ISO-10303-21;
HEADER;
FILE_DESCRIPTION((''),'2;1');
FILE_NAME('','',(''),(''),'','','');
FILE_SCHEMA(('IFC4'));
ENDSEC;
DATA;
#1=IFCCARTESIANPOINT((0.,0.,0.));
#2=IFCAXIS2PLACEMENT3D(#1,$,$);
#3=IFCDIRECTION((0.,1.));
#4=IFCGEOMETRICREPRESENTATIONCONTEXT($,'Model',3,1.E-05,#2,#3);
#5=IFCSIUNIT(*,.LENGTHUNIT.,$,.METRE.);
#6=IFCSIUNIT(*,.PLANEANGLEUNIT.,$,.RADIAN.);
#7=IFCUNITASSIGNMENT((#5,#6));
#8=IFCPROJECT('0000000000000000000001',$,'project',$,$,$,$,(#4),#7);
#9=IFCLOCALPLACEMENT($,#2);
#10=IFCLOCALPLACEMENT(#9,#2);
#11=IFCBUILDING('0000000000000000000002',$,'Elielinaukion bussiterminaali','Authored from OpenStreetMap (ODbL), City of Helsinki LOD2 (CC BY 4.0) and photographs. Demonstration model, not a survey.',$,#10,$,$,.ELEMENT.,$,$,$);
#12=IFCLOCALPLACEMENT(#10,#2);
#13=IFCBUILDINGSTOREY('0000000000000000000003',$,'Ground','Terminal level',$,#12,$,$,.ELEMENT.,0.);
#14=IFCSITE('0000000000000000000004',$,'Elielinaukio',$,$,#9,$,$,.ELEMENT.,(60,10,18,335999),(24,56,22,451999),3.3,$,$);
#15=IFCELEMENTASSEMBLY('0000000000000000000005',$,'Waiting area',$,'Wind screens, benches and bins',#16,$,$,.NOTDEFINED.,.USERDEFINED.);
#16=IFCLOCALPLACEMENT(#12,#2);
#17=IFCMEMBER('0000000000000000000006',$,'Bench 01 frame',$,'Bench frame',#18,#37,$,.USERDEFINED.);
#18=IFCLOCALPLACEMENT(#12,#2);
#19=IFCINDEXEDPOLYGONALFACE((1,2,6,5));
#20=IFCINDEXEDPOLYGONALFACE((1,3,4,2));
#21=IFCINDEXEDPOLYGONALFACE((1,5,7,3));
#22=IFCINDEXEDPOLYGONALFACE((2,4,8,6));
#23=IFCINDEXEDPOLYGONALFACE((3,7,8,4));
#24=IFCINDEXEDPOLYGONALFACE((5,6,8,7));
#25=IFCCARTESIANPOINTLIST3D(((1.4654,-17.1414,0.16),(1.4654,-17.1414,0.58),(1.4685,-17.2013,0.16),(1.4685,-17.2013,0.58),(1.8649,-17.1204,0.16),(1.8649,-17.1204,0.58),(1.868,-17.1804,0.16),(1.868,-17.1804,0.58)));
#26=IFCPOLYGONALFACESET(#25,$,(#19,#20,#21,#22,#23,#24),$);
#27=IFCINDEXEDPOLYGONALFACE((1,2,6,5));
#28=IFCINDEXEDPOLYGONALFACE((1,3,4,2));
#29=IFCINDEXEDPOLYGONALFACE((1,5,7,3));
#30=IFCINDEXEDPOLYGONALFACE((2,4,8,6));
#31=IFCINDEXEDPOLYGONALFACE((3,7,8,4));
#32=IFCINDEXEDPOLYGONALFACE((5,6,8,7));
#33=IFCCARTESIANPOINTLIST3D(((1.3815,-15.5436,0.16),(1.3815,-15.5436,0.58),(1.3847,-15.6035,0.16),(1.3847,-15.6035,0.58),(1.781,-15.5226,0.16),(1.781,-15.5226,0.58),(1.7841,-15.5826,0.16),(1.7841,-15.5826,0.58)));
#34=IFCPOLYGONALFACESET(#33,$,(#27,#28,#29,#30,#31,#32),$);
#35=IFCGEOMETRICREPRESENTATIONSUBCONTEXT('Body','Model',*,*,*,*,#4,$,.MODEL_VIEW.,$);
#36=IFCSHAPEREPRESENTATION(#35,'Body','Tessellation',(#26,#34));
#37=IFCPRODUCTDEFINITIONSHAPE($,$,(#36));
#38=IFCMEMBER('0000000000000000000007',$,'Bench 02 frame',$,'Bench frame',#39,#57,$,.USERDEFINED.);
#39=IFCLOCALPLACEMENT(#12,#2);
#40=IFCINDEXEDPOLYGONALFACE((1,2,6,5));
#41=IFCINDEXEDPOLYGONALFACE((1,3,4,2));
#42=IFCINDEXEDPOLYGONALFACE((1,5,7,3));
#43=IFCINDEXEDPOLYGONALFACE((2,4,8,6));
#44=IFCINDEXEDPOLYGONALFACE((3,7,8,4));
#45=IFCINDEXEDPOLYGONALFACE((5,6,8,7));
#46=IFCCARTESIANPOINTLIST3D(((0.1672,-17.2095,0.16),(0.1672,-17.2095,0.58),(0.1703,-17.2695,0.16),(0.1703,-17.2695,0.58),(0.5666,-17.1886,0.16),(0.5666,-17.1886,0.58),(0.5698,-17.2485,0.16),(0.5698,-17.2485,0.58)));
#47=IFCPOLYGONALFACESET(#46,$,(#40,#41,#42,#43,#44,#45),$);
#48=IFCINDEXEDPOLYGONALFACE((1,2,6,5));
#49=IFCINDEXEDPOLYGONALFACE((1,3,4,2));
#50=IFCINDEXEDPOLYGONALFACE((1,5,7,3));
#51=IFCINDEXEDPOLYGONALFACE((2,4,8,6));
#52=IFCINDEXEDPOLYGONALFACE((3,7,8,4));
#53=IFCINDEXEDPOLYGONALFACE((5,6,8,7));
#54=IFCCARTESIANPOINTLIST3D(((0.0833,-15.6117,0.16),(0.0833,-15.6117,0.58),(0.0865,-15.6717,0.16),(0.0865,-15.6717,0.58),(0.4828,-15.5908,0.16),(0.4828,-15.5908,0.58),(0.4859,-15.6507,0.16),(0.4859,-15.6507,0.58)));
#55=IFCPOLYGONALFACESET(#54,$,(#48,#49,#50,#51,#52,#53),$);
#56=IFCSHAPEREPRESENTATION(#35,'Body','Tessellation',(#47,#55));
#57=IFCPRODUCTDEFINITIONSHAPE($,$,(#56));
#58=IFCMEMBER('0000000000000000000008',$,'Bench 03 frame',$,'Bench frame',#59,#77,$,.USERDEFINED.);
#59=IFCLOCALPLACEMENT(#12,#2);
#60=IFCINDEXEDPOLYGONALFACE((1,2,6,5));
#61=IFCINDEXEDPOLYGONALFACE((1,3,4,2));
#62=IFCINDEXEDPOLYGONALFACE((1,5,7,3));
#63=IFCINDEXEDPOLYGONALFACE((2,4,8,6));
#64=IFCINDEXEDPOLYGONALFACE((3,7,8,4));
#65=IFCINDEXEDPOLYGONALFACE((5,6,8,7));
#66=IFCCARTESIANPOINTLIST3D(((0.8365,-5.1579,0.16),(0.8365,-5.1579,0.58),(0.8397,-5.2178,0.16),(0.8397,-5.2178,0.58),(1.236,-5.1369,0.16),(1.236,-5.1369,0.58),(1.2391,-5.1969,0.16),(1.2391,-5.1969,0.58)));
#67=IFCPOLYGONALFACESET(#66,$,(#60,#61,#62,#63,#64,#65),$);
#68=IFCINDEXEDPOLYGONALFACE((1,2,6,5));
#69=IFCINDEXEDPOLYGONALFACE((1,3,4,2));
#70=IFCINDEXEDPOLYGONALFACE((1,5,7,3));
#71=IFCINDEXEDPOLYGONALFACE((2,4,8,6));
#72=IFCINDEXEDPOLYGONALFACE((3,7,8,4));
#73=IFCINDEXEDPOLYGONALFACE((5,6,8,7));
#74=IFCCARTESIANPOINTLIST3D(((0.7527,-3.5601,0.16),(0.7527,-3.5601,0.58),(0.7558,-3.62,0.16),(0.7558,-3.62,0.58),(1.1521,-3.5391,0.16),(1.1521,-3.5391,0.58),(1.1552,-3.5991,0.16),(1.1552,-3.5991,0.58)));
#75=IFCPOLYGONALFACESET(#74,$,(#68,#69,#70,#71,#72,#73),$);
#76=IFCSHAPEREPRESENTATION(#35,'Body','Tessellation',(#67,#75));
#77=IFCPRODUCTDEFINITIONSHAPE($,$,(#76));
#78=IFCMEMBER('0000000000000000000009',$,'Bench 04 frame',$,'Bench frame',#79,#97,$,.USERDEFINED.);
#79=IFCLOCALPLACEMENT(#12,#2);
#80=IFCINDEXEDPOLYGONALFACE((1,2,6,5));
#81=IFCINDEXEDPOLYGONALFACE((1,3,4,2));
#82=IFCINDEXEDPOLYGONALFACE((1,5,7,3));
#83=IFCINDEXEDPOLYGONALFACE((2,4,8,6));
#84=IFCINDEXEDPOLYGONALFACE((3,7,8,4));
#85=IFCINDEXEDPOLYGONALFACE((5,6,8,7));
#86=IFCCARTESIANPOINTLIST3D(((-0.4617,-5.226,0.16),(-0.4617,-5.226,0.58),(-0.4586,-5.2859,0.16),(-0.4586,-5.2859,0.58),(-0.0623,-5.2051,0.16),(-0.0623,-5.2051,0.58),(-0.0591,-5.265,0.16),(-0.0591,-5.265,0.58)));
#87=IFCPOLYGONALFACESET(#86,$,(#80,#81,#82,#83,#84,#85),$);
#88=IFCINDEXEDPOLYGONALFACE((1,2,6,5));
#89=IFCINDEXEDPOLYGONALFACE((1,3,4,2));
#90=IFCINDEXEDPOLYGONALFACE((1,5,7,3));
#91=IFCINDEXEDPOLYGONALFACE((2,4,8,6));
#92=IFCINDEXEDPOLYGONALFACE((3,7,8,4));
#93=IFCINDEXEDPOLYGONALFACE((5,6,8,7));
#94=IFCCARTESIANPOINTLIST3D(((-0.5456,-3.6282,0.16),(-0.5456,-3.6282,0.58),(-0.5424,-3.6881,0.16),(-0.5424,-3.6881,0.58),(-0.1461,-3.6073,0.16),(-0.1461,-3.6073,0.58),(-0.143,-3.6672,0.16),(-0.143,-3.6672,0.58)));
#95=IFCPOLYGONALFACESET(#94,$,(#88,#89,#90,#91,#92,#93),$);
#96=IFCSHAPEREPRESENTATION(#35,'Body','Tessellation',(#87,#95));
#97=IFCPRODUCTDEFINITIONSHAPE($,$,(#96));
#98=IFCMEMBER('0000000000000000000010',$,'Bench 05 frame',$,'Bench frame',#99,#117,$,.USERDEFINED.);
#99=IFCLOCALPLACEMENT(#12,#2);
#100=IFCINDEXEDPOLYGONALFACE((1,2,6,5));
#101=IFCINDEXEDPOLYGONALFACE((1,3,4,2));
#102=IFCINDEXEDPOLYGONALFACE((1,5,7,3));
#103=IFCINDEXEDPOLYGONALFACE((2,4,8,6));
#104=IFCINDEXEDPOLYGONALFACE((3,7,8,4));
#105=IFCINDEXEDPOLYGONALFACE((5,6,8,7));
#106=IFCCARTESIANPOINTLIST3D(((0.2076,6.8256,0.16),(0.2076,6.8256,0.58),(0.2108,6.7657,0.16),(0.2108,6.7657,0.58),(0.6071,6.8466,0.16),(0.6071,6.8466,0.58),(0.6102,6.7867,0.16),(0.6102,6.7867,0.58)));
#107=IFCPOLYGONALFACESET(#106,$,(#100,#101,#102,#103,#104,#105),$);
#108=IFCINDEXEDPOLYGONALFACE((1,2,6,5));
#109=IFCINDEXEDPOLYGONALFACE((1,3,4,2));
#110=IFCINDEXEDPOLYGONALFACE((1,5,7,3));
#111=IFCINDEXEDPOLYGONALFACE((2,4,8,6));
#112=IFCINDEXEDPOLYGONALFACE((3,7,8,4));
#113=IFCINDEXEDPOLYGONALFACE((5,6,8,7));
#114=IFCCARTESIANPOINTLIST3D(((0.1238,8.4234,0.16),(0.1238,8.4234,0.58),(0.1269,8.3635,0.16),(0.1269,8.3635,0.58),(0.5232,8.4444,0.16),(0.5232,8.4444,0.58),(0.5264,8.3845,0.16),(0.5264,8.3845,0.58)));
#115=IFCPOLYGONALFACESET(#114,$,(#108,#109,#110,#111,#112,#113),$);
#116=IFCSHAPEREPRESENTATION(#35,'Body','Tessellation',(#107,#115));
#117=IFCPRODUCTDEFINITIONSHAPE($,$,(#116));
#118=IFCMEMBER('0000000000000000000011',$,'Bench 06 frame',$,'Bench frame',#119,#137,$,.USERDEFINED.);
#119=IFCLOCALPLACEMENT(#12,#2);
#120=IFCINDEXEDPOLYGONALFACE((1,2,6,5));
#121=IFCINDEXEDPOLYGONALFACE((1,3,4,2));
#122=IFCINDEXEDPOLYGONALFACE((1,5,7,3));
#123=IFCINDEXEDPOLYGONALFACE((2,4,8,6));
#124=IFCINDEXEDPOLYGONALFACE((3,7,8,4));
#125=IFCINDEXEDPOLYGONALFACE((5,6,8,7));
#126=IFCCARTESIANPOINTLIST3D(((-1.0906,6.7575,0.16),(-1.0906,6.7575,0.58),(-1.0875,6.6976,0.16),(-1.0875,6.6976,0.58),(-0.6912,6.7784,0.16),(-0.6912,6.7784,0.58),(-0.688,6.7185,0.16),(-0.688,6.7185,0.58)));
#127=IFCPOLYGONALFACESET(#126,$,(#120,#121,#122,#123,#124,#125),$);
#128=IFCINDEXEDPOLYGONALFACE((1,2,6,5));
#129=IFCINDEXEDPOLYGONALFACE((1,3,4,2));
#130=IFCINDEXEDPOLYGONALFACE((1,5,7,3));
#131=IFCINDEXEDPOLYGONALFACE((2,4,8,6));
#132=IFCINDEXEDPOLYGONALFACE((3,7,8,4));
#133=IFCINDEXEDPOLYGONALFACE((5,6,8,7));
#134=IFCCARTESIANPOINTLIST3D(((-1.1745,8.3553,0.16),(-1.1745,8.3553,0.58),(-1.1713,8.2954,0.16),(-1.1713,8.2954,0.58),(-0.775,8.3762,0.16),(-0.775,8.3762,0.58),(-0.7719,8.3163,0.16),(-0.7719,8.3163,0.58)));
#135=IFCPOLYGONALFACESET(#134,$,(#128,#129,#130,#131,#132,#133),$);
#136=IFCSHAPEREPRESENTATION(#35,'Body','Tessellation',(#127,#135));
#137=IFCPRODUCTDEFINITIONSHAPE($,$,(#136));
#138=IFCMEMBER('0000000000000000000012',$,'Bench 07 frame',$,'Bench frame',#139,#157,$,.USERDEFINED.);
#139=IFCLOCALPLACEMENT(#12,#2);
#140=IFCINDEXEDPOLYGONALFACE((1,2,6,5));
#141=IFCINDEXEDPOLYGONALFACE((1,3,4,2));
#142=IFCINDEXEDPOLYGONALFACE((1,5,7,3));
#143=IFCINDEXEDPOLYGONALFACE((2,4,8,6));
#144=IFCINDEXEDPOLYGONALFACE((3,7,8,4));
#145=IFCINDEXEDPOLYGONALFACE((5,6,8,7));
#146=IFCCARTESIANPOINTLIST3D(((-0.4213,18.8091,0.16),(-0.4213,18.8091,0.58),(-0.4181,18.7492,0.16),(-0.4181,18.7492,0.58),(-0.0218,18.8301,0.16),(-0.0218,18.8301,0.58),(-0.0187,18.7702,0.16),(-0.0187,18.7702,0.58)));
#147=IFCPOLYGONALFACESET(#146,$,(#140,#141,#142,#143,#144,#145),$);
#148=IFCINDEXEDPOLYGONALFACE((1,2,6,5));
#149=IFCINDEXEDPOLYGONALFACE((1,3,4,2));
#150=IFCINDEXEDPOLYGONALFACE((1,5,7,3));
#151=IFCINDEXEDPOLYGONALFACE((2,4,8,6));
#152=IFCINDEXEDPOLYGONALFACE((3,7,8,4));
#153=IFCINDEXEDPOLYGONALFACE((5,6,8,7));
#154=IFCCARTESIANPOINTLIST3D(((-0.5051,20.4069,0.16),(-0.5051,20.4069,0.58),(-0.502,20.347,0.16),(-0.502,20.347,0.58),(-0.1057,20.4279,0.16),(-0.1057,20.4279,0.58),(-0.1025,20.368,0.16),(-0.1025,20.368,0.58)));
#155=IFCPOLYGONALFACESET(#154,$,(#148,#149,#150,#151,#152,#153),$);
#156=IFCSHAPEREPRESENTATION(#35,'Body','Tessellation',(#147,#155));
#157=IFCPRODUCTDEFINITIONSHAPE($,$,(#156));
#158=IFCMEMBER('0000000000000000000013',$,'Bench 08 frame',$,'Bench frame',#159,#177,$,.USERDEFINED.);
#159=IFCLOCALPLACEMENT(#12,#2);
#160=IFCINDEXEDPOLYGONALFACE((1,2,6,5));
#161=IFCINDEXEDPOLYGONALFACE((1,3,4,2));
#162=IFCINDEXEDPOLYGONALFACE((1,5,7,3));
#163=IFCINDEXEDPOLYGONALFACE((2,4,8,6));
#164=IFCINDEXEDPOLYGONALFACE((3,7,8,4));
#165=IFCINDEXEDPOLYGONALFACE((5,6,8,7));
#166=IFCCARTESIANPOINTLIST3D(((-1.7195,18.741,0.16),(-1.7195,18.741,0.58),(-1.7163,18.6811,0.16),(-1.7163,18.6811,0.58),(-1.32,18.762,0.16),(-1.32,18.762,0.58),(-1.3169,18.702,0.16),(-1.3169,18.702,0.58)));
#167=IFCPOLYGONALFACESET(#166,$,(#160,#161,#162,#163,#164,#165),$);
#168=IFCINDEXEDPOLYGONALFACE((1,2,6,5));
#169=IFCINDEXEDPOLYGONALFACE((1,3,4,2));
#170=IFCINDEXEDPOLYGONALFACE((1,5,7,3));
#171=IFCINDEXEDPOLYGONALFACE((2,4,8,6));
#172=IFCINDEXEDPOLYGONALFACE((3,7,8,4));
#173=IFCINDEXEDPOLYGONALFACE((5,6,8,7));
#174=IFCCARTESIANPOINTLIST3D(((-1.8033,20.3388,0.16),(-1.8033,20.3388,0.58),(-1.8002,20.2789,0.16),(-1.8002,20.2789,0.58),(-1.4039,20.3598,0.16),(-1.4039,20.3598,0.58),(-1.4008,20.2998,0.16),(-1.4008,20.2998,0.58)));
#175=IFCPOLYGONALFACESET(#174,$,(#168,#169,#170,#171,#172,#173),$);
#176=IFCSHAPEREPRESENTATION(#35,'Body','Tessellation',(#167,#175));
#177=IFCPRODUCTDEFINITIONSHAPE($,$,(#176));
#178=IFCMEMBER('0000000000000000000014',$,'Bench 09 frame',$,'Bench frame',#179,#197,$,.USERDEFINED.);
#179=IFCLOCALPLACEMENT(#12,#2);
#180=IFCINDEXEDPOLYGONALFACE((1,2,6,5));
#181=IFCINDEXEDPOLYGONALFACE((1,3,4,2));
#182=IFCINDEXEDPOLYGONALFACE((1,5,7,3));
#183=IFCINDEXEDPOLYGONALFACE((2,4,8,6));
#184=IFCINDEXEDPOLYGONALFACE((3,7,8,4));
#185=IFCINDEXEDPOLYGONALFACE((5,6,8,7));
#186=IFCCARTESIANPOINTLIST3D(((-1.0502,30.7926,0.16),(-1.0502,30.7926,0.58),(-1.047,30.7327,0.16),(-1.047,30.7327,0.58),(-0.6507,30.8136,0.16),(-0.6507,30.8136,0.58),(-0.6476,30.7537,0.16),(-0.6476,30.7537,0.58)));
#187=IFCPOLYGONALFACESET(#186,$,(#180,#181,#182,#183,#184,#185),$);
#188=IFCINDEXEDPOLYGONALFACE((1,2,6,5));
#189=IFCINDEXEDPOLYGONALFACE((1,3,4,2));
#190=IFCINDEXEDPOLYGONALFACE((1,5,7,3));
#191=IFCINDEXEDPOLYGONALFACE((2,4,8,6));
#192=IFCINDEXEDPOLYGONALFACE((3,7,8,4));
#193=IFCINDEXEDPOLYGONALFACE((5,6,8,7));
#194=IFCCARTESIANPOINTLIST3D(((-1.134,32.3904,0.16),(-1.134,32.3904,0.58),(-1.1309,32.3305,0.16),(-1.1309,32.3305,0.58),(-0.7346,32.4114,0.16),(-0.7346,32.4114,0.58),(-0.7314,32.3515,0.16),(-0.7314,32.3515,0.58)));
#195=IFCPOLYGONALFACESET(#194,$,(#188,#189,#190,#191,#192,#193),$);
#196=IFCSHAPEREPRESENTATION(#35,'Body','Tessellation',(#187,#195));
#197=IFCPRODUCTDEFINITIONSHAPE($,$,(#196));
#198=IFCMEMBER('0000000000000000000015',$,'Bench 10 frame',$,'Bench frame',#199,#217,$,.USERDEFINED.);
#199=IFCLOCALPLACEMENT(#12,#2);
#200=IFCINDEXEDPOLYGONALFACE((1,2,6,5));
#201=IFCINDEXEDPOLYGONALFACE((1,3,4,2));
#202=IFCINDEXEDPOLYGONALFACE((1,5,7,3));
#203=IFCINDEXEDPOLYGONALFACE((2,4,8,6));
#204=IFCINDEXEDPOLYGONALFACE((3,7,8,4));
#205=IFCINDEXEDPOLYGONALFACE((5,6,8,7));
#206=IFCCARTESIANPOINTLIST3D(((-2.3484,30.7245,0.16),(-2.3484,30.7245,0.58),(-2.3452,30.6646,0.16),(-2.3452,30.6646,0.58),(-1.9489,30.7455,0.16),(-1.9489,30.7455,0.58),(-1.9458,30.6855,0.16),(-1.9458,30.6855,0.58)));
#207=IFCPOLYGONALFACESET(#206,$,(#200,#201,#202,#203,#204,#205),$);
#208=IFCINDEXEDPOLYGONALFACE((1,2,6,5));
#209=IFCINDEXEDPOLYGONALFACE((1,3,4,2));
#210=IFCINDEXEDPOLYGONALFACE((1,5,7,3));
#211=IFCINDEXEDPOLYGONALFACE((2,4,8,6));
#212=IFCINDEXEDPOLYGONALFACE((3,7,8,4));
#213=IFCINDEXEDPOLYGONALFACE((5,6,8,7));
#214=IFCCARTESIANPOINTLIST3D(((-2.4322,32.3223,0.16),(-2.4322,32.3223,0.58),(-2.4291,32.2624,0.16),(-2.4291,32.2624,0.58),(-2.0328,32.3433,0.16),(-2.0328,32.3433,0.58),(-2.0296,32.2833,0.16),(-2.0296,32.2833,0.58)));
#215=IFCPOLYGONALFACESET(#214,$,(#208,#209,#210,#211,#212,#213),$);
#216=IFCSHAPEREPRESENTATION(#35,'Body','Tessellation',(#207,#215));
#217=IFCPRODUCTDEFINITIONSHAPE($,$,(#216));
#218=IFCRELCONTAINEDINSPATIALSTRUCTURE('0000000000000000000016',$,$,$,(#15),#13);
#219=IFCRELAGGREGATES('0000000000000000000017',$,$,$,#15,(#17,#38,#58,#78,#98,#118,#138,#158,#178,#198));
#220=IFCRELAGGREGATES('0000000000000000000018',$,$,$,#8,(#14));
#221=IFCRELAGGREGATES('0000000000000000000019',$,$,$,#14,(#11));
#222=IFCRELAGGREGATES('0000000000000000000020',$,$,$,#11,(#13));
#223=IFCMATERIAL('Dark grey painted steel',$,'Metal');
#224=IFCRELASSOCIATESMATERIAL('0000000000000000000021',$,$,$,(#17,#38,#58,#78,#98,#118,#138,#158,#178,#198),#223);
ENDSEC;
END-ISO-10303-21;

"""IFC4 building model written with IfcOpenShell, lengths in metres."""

from ifc_helpers import new_model, si_unit, direction, frame, frame_2d, origin, place, context, subcontext, project, spatial, rectangle, extrude, material, element, aggregate, save


model = new_model("IFC4")

# Units and contexts
model_context = context("Model", 3, precision=1e-05, world=origin(), true_north=direction((0.0, 1.0)))
body_context = subcontext(model_context, "Body", "Model", "MODEL_VIEW")
ifc_project = project(units=[si_unit("LENGTHUNIT", "METRE"), si_unit("PLANEANGLEUNIT", "RADIAN")], contexts=[model_context])

# Site, building, storey
site_placement = place(None, origin())
site = spatial("IfcSite", under=ifc_project, at=site_placement, Name="Elielinaukio", CompositionType="ELEMENT", RefLatitude=(60, 10, 18, 335999), RefLongitude=(24, 56, 22, 451999), RefElevation=3.3)
building_placement = place(site_placement, origin())
building = spatial("IfcBuilding", under=site, at=building_placement, Name="Elielinaukion bussiterminaali", Description="Authored from OpenStreetMap (ODbL), City of Helsinki LOD2 (CC BY 4.0) and photographs. Demonstration model, not a survey.", CompositionType="ELEMENT")
storey_placement = place(building_placement, origin())
storey = spatial("IfcBuildingStorey", under=building, at=storey_placement, Name="Ground", Description="Terminal level", CompositionType="ELEMENT", Elevation=0.0)

# Element assembly, members
assembly_1_placement = place(building_placement, origin())
assembly_1 = element("IfcElementAssembly", 1, at=assembly_1_placement, inside=storey, Name="Waiting area", ObjectType="Wind screens, benches and bins", AssemblyPlace="NOTDEFINED", PredefinedType="USERDEFINED")
ifc_material_1 = material(Name="Dark grey painted steel", Category="Metal")
member_1_placement = place(building_placement, origin())
member_1 = element("IfcMember", 2, at=member_1_placement, material=ifc_material_1, Name="Bench 01 frame", ObjectType="Bench frame", PredefinedType="USERDEFINED", context=body_context, shape_type="SweptSolid", body=[
    extrude(rectangle(XDim=0.06, YDim=0.4, at=frame_2d((0.0, 0.0), x_axis=(-0.052408, 0.998626))), frame((1.6667, -17.1609, 0.16)), (0.0, 0.0, 1.0), 0.42),
    extrude(rectangle(XDim=0.06, YDim=0.4, at=frame_2d((0.0, 0.0), x_axis=(-0.052408, 0.998626))), frame((1.5828, -15.5631, 0.16)), (0.0, 0.0, 1.0), 0.42),
])
member_2_placement = place(building_placement, origin())
member_2 = element("IfcMember", 3, at=member_2_placement, material=ifc_material_1, Name="Bench 02 frame", ObjectType="Bench frame", PredefinedType="USERDEFINED", context=body_context, shape_type="SweptSolid", body=[
    extrude(rectangle(XDim=0.06, YDim=0.4, at=frame_2d((0.0, 0.0), x_axis=(-0.052408, 0.998626))), frame((0.3685, -17.229, 0.16)), (0.0, 0.0, 1.0), 0.42),
    extrude(rectangle(XDim=0.06, YDim=0.4, at=frame_2d((0.0, 0.0), x_axis=(-0.052408, 0.998626))), frame((0.2846, -15.6312, 0.16)), (0.0, 0.0, 1.0), 0.42),
])
member_3_placement = place(building_placement, origin())
member_3 = element("IfcMember", 4, at=member_3_placement, material=ifc_material_1, Name="Bench 03 frame", ObjectType="Bench frame", PredefinedType="USERDEFINED", context=body_context, shape_type="SweptSolid", body=[
    extrude(rectangle(XDim=0.06, YDim=0.4, at=frame_2d((0.0, 0.0), x_axis=(-0.052408, 0.998626))), frame((1.0378, -5.1774, 0.16)), (0.0, 0.0, 1.0), 0.42),
    extrude(rectangle(XDim=0.06, YDim=0.4, at=frame_2d((0.0, 0.0), x_axis=(-0.052408, 0.998626))), frame((0.954, -3.5796, 0.16)), (0.0, 0.0, 1.0), 0.42),
])
member_4_placement = place(building_placement, origin())
member_4 = element("IfcMember", 5, at=member_4_placement, material=ifc_material_1, Name="Bench 04 frame", ObjectType="Bench frame", PredefinedType="USERDEFINED", context=body_context, shape_type="SweptSolid", body=[
    extrude(rectangle(XDim=0.06, YDim=0.4, at=frame_2d((0.0, 0.0), x_axis=(-0.052408, 0.998626))), frame((-0.2604, -5.2455, 0.16)), (0.0, 0.0, 1.0), 0.42),
    extrude(rectangle(XDim=0.06, YDim=0.4, at=frame_2d((0.0, 0.0), x_axis=(-0.052408, 0.998626))), frame((-0.3443, -3.6477, 0.16)), (0.0, 0.0, 1.0), 0.42),
])
member_5_placement = place(building_placement, origin())
member_5 = element("IfcMember", 6, at=member_5_placement, material=ifc_material_1, Name="Bench 05 frame", ObjectType="Bench frame", PredefinedType="USERDEFINED", context=body_context, shape_type="SweptSolid", body=[
    extrude(rectangle(XDim=0.06, YDim=0.4, at=frame_2d((0.0, 0.0), x_axis=(-0.052408, 0.998626))), frame((0.4089, 6.8061, 0.16)), (0.0, 0.0, 1.0), 0.42),
    extrude(rectangle(XDim=0.06, YDim=0.4, at=frame_2d((0.0, 0.0), x_axis=(-0.052408, 0.998626))), frame((0.3251, 8.4039, 0.16)), (0.0, 0.0, 1.0), 0.42),
])
member_6_placement = place(building_placement, origin())
member_6 = element("IfcMember", 7, at=member_6_placement, material=ifc_material_1, Name="Bench 06 frame", ObjectType="Bench frame", PredefinedType="USERDEFINED", context=body_context, shape_type="SweptSolid", body=[
    extrude(rectangle(XDim=0.06, YDim=0.4, at=frame_2d((0.0, 0.0), x_axis=(-0.052408, 0.998626))), frame((-0.8893, 6.738, 0.16)), (0.0, 0.0, 1.0), 0.42),
    extrude(rectangle(XDim=0.06, YDim=0.4, at=frame_2d((0.0, 0.0), x_axis=(-0.052408, 0.998626))), frame((-0.9732, 8.3358, 0.16)), (0.0, 0.0, 1.0), 0.42),
])
member_7_placement = place(building_placement, origin())
member_7 = element("IfcMember", 8, at=member_7_placement, material=ifc_material_1, Name="Bench 07 frame", ObjectType="Bench frame", PredefinedType="USERDEFINED", context=body_context, shape_type="SweptSolid", body=[
    extrude(rectangle(XDim=0.06, YDim=0.4, at=frame_2d((0.0, 0.0), x_axis=(-0.052408, 0.998626))), frame((-0.22, 18.7896, 0.16)), (0.0, 0.0, 1.0), 0.42),
    extrude(rectangle(XDim=0.06, YDim=0.4, at=frame_2d((0.0, 0.0), x_axis=(-0.052408, 0.998626))), frame((-0.3038, 20.3874, 0.16)), (0.0, 0.0, 1.0), 0.42),
])
member_8_placement = place(building_placement, origin())
member_8 = element("IfcMember", 9, at=member_8_placement, material=ifc_material_1, Name="Bench 08 frame", ObjectType="Bench frame", PredefinedType="USERDEFINED", context=body_context, shape_type="SweptSolid", body=[
    extrude(rectangle(XDim=0.06, YDim=0.4, at=frame_2d((0.0, 0.0), x_axis=(-0.052408, 0.998626))), frame((-1.5182, 18.7215, 0.16)), (0.0, 0.0, 1.0), 0.42),
    extrude(rectangle(XDim=0.06, YDim=0.4, at=frame_2d((0.0, 0.0), x_axis=(-0.052408, 0.998626))), frame((-1.602, 20.3193, 0.16)), (0.0, 0.0, 1.0), 0.42),
])
member_9_placement = place(building_placement, origin())
member_9 = element("IfcMember", 10, at=member_9_placement, material=ifc_material_1, Name="Bench 09 frame", ObjectType="Bench frame", PredefinedType="USERDEFINED", context=body_context, shape_type="SweptSolid", body=[
    extrude(rectangle(XDim=0.06, YDim=0.4, at=frame_2d((0.0, 0.0), x_axis=(-0.052408, 0.998626))), frame((-0.8489, 30.7732, 0.16)), (0.0, 0.0, 1.0), 0.42),
    extrude(rectangle(XDim=0.06, YDim=0.4, at=frame_2d((0.0, 0.0), x_axis=(-0.052408, 0.998626))), frame((-0.9327, 32.371, 0.16)), (0.0, 0.0, 1.0), 0.42),
])
member_10_placement = place(building_placement, origin())
member_10 = element("IfcMember", 11, at=member_10_placement, material=ifc_material_1, Name="Bench 10 frame", ObjectType="Bench frame", PredefinedType="USERDEFINED", context=body_context, shape_type="SweptSolid", body=[
    extrude(rectangle(XDim=0.06, YDim=0.4, at=frame_2d((0.0, 0.0), x_axis=(-0.052408, 0.998626))), frame((-2.1471, 30.705, 0.16)), (0.0, 0.0, 1.0), 0.42),
    extrude(rectangle(XDim=0.06, YDim=0.4, at=frame_2d((0.0, 0.0), x_axis=(-0.052408, 0.998626))), frame((-2.2309, 32.3028, 0.16)), (0.0, 0.0, 1.0), 0.42),
])

aggregate(assembly_1, [member_1, member_2, member_3, member_4, member_5, member_6, member_7, member_8, member_9, member_10])

save(model, "model.ifc")
